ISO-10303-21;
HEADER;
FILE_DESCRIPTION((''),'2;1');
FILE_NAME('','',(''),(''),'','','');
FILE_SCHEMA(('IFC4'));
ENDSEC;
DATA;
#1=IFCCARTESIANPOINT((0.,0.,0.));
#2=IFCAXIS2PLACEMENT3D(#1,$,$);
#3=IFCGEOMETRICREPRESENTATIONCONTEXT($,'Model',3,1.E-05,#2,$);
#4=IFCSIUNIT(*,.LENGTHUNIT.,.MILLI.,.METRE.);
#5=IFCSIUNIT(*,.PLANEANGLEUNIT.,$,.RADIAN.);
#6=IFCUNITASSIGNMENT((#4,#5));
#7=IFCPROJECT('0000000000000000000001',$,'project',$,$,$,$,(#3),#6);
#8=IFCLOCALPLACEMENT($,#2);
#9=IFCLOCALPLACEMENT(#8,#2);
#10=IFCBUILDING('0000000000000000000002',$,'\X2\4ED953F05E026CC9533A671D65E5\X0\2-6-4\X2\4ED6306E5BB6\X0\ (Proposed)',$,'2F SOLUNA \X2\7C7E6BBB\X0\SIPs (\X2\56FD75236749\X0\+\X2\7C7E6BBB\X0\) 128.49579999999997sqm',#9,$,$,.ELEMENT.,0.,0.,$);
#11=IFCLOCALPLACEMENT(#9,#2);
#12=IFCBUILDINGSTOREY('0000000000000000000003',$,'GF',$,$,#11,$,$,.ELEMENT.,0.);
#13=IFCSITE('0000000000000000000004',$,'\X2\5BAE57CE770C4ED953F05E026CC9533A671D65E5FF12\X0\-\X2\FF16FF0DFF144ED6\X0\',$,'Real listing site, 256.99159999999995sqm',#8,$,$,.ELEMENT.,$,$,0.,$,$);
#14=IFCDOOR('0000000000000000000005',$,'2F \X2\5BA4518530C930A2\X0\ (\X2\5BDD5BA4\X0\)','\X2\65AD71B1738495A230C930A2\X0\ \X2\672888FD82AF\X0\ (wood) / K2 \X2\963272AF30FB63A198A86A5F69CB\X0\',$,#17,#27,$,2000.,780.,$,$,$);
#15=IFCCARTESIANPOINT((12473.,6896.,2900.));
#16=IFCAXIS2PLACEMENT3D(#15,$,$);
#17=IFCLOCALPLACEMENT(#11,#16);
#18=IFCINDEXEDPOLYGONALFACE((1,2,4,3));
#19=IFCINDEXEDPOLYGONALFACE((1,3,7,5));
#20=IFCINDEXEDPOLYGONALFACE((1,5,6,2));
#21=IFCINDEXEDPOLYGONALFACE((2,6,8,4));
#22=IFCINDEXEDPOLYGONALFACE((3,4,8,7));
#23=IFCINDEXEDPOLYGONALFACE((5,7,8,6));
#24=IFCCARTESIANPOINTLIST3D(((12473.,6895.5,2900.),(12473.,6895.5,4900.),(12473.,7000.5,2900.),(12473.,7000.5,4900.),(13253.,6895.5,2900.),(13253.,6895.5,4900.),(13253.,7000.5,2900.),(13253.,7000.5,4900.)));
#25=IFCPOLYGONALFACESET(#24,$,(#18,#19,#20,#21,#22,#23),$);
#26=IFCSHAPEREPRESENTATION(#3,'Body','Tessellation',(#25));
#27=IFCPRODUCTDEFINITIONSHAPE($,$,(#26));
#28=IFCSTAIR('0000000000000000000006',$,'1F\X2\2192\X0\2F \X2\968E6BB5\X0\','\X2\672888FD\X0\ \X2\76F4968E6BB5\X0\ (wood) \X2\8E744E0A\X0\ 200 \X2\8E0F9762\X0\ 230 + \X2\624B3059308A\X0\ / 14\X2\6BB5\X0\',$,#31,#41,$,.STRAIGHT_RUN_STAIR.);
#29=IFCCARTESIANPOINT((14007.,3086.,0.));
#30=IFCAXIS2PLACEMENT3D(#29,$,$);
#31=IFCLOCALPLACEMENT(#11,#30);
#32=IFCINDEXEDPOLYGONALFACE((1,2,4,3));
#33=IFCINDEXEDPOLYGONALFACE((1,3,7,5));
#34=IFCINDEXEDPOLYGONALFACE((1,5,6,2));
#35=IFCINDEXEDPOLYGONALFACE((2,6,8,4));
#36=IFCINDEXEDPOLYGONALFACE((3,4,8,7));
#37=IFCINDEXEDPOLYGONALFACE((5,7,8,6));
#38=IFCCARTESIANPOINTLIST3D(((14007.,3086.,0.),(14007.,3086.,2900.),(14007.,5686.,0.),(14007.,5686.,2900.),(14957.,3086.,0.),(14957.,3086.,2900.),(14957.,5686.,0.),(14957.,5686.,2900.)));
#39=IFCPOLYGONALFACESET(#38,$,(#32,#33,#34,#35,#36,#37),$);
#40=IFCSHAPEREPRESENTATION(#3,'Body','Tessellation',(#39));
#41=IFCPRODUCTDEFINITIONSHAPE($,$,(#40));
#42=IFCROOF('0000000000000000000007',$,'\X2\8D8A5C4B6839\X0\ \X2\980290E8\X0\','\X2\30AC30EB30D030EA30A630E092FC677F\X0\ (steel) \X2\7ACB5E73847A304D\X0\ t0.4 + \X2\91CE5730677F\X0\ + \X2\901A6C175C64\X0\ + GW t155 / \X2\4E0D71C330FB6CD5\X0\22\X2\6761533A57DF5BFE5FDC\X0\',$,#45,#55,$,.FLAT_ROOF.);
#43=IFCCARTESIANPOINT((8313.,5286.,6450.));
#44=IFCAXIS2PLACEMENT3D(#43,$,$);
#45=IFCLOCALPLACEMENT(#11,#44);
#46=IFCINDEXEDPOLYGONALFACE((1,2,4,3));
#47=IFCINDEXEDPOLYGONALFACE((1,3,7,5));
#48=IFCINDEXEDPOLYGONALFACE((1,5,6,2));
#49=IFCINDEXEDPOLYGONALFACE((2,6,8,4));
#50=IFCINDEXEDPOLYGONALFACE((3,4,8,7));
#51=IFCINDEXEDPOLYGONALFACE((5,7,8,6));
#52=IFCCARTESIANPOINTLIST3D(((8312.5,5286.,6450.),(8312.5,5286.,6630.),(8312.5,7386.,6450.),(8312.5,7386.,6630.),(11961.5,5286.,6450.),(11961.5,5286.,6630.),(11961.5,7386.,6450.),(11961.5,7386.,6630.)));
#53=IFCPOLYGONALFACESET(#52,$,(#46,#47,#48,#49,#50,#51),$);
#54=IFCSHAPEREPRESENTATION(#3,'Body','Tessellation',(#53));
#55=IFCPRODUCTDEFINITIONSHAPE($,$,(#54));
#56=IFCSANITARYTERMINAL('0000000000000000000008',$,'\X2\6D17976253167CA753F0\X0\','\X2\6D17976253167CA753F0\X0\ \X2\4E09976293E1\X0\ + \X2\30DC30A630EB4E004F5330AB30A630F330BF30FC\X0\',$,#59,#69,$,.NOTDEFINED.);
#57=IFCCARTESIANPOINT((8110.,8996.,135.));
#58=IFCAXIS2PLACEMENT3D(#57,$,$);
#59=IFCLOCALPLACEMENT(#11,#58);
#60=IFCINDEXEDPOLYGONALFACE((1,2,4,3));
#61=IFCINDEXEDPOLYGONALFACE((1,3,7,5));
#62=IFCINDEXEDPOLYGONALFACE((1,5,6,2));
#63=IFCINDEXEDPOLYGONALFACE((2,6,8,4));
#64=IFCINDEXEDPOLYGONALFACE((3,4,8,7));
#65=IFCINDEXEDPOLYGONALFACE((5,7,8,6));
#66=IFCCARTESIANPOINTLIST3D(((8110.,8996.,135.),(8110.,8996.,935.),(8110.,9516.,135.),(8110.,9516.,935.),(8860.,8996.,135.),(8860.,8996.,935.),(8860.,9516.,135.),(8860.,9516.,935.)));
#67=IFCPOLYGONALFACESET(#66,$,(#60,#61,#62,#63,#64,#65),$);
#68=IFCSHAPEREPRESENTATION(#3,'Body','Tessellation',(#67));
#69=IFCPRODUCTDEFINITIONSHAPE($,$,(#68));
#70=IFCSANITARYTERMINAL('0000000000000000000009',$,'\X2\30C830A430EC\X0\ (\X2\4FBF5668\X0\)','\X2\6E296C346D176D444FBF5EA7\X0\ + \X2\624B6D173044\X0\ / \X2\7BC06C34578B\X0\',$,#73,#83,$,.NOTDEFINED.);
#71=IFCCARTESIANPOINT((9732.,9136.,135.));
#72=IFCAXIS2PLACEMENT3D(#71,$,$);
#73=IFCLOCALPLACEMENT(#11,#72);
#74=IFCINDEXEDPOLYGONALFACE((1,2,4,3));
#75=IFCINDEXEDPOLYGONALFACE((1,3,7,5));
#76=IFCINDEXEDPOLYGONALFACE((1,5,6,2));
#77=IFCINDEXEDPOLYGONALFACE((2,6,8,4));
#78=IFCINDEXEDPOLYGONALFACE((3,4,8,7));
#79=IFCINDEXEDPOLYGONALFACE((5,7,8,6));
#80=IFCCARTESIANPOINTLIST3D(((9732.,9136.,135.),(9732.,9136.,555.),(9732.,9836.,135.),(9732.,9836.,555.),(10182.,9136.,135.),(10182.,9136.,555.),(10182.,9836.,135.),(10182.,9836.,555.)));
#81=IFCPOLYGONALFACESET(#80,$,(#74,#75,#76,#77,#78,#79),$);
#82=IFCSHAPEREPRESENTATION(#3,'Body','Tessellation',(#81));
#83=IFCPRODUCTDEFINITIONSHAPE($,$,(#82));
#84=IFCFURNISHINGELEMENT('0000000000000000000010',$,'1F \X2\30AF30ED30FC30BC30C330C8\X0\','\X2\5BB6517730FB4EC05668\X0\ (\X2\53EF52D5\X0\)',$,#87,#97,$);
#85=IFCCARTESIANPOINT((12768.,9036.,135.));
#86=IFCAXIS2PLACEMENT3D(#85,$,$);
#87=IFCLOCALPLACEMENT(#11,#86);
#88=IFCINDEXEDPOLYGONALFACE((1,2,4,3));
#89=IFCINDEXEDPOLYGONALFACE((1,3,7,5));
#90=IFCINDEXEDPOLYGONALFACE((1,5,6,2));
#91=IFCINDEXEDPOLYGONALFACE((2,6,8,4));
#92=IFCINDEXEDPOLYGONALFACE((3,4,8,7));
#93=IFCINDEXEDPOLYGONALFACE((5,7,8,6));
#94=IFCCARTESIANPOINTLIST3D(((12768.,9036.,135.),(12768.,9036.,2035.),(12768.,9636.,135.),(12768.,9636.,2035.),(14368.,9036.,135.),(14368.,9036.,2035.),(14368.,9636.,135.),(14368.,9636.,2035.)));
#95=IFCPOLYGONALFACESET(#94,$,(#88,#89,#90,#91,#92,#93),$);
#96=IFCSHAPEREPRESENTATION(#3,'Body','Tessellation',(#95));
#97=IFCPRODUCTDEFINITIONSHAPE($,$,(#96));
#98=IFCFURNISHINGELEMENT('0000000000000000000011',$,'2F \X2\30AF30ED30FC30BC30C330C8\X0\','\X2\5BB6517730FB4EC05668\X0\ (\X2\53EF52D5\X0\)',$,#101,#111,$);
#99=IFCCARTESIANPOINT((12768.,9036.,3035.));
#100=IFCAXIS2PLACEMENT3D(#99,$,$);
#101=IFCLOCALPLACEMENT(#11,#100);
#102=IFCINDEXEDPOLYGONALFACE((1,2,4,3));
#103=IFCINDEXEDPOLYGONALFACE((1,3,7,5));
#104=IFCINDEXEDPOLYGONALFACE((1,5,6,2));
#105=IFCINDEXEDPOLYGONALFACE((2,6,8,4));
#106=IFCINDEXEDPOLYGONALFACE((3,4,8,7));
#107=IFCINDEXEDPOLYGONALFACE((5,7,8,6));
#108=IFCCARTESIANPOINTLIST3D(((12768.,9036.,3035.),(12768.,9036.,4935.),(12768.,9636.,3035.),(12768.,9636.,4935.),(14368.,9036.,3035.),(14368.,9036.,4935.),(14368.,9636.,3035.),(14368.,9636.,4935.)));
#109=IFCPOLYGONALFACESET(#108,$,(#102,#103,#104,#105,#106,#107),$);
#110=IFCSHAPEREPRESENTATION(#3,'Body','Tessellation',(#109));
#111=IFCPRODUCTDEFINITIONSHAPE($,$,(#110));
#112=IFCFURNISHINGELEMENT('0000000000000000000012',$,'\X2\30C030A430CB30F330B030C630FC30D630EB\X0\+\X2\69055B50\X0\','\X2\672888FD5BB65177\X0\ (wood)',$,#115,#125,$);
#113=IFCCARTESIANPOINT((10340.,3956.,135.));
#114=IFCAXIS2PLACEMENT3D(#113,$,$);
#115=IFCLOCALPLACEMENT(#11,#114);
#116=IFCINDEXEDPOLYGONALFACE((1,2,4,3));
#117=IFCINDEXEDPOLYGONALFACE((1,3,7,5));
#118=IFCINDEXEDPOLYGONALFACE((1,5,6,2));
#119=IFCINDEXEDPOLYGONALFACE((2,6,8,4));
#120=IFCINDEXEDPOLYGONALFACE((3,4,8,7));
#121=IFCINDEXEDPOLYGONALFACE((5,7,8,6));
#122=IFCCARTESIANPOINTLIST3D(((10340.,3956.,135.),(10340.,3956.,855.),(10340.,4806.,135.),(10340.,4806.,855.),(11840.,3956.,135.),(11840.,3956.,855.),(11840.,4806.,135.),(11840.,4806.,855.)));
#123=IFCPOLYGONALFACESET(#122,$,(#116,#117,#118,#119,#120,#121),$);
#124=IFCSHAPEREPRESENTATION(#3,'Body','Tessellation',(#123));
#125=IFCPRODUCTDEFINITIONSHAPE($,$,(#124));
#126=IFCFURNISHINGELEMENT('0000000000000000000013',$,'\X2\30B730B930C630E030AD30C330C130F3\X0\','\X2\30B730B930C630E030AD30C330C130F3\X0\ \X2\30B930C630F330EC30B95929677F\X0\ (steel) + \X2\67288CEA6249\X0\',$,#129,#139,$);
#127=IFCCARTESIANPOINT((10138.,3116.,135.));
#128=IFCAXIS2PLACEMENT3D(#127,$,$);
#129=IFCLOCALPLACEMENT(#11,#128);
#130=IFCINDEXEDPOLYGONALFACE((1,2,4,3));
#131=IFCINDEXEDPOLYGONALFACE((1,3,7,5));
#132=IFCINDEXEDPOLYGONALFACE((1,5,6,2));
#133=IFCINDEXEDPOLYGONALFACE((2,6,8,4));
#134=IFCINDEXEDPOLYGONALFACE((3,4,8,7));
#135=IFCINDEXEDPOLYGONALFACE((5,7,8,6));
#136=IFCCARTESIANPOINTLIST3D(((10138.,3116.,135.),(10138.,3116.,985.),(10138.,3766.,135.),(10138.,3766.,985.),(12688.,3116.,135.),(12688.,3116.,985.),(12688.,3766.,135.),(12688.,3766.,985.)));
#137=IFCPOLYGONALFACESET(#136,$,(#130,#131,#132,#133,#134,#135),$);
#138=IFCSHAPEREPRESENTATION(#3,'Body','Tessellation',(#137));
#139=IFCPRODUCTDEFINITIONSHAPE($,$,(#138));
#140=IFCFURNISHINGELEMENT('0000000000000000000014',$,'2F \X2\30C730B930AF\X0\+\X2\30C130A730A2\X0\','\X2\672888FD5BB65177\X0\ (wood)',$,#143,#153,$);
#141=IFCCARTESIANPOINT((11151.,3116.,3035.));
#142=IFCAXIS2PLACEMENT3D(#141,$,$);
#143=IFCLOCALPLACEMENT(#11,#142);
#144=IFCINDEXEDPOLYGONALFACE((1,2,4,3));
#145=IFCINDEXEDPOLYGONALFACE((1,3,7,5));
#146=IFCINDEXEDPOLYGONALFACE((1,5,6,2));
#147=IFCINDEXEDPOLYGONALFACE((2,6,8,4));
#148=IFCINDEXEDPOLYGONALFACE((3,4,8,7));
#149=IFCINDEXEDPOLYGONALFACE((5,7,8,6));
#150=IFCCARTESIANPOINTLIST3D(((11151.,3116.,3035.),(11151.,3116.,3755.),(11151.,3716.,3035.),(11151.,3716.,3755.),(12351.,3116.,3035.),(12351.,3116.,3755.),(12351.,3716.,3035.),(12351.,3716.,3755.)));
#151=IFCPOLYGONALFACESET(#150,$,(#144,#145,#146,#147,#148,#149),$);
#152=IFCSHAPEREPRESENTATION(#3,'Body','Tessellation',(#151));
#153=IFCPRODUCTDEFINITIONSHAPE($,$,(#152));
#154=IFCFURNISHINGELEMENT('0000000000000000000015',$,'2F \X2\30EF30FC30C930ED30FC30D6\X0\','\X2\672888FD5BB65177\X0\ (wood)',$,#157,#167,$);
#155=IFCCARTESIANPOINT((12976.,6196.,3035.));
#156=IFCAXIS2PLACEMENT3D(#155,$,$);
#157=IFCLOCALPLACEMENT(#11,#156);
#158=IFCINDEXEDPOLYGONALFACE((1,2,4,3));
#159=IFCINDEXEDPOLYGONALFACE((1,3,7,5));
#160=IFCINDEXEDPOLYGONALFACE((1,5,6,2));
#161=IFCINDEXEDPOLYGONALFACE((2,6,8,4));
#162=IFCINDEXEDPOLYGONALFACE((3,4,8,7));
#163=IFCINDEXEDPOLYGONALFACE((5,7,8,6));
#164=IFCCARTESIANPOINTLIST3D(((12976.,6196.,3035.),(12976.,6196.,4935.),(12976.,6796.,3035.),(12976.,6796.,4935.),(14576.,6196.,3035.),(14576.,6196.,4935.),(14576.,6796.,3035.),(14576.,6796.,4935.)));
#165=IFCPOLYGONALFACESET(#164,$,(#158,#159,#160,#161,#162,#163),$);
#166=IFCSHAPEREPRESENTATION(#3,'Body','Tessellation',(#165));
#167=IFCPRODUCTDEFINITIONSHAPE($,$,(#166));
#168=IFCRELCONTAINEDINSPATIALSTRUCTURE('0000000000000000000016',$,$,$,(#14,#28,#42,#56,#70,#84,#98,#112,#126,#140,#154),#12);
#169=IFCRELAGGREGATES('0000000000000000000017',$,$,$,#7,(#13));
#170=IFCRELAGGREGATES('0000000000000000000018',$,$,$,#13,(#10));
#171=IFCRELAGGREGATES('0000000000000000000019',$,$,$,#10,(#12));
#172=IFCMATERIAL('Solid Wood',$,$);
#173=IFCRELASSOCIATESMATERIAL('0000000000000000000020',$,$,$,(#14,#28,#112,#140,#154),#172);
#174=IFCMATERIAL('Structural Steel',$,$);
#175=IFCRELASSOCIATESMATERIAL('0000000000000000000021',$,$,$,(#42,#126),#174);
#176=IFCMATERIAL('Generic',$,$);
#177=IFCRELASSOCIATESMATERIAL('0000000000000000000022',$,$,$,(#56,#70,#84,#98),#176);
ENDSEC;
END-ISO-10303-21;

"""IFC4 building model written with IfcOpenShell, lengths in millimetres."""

from ifc_helpers import new_model, si_unit, frame, frame_2d, origin, place, context, project, spatial, rectangle, extrude, material, element, save


model = new_model("IFC4")

# Units and contexts
model_context = context("Model", 3, precision=1e-05, world=origin())
ifc_project = project(units=[si_unit("LENGTHUNIT", "METRE", prefix="MILLI"), si_unit("PLANEANGLEUNIT", "RADIAN")], contexts=[model_context])

# Site, building, storey
site_placement = place(None, origin())
site = spatial("IfcSite", under=ifc_project, at=site_placement, Name="宮城県仙台市泉区朝日２-６－４他", ObjectType="Real listing site, 256.99159999999995sqm", CompositionType="ELEMENT", RefElevation=0.0)
building_placement = place(site_placement, origin())
building = spatial("IfcBuilding", under=site, at=building_placement, Name="仙台市泉区朝日2-6-4他の家 (Proposed)", ObjectType="2F SOLUNA 籾殻SIPs (国産杉+籾殻) 128.49579999999997sqm", CompositionType="ELEMENT", ElevationOfRefHeight=0.0, ElevationOfTerrain=0.0)
storey_placement = place(building_placement, origin())
storey = spatial("IfcBuildingStorey", under=building, at=storey_placement, Name="GF", CompositionType="ELEMENT", Elevation=0.0)

# Shared definitions
ifc_material_1 = material(Name="Solid Wood")

# Door
door_1_placement = place(storey_placement, frame((12473.0, 6896.0, 2900.0)))
element("IfcDoor", 1, at=door_1_placement, inside=storey, material=ifc_material_1, Name="2F 室内ドア (寝室)", Description="断熱玄関ドア 木製芯 (wood) / K2 防犯・採風機構", OverallHeight=2000.0, OverallWidth=780.0, context=model_context, shape_type="SweptSolid", body=[
    extrude(rectangle(XDim=780.0, YDim=105.0, at=frame_2d((390.0, 52.0))), frame((12473.0, 6896.0, 2900.0)), (0.0, 0.0, 1.0), 2000.0),
])

# Stair
stair_placement = place(storey_placement, frame((14007.0, 3086.0, 0.0)))
element("IfcStair", 2, at=stair_placement, inside=storey, material=ifc_material_1, Name="1F→2F 階段", Description="木製 直階段 (wood) 蹴上 200 踏面 230 + 手すり / 14段", PredefinedType="STRAIGHT_RUN_STAIR", context=model_context, shape_type="SweptSolid", body=[
    extrude(rectangle(XDim=950.0, YDim=2600.0, at=frame_2d((475.0, 1300.0))), frame((14007.0, 3086.0, 0.0)), (0.0, 0.0, 1.0), 2900.0),
])

# Roof
ifc_material_2 = material(Name="Structural Steel")
roof_placement = place(storey_placement, frame((8313.0, 5286.0, 6450.0)))
element("IfcRoof", 3, at=roof_placement, inside=storey, material=ifc_material_2, Name="越屋根 頂部", Description="ガルバリウム鋼板 (steel) 立平葺き t0.4 + 野地板 + 通気層 + GW t155 / 不燃・法22条区域対応", PredefinedType="FLAT_ROOF", context=model_context, shape_type="SweptSolid", body=[
    extrude(rectangle(XDim=3649.0, YDim=2100.0, at=frame_2d((1824.0, 1050.0))), frame((8313.0, 5286.0, 6450.0)), (0.0, 0.0, 1.0), 180.0),
])

# Sanitary terminals
ifc_material_3 = material(Name="Generic")
sanitary_terminal_1_placement = place(storey_placement, frame((8110.0, 8996.0, 135.0)))
element("IfcSanitaryTerminal", 4, at=sanitary_terminal_1_placement, inside=storey, material=ifc_material_3, Name="洗面化粧台", Description="洗面化粧台 三面鏡 + ボウル一体カウンター", PredefinedType="NOTDEFINED", context=model_context, shape_type="SweptSolid", body=[
    extrude(rectangle(XDim=750.0, YDim=520.0, at=frame_2d((375.0, 260.0))), frame((8110.0, 8996.0, 135.0)), (0.0, 0.0, 1.0), 800.0),
])
sanitary_terminal_2_placement = place(storey_placement, frame((9732.0, 9136.0, 135.0)))
element("IfcSanitaryTerminal", 5, at=sanitary_terminal_2_placement, inside=storey, material=ifc_material_3, Name="トイレ (便器)", Description="温水洗浄便座 + 手洗い / 節水型", PredefinedType="NOTDEFINED", context=model_context, shape_type="SweptSolid", body=[
    extrude(rectangle(XDim=450.0, YDim=700.0, at=frame_2d((225.0, 350.0))), frame((9732.0, 9136.0, 135.0)), (0.0, 0.0, 1.0), 420.0),
])

# Furnishing elements
furnishing_1_placement = place(storey_placement, frame((12768.0, 9036.0, 135.0)))
element("IfcFurnishingElement", 6, at=furnishing_1_placement, inside=storey, material=ifc_material_3, Name="1F クローゼット", Description="家具・什器 (可動)", context=model_context, shape_type="SweptSolid", body=[
    extrude(rectangle(XDim=1600.0, YDim=600.0, at=frame_2d((800.0, 300.0))), frame((12768.0, 9036.0, 135.0)), (0.0, 0.0, 1.0), 1900.0),
])
furnishing_2_placement = place(storey_placement, frame((12768.0, 9036.0, 3035.0)))
element("IfcFurnishingElement", 7, at=furnishing_2_placement, inside=storey, material=ifc_material_3, Name="2F クローゼット", Description="家具・什器 (可動)", context=model_context, shape_type="SweptSolid", body=[
    extrude(rectangle(XDim=1600.0, YDim=600.0, at=frame_2d((800.0, 300.0))), frame((12768.0, 9036.0, 3035.0)), (0.0, 0.0, 1.0), 1900.0),
])
furnishing_3_placement = place(storey_placement, frame((10340.0, 3956.0, 135.0)))
element("IfcFurnishingElement", 8, at=furnishing_3_placement, inside=storey, material=ifc_material_1, Name="ダイニングテーブル+椅子", Description="木製家具 (wood)", context=model_context, shape_type="SweptSolid", body=[
    extrude(rectangle(XDim=1500.0, YDim=850.0, at=frame_2d((750.0, 425.0))), frame((10340.0, 3956.0, 135.0)), (0.0, 0.0, 1.0), 720.0),
])
furnishing_4_placement = place(storey_placement, frame((10138.0, 3116.0, 135.0)))
element("IfcFurnishingElement", 9, at=furnishing_4_placement, inside=storey, material=ifc_material_2, Name="システムキッチン", Description="システムキッチン ステンレス天板 (steel) + 木質扉", context=model_context, shape_type="SweptSolid", body=[
    extrude(rectangle(XDim=2550.0, YDim=650.0, at=frame_2d((1275.0, 325.0))), frame((10138.0, 3116.0, 135.0)), (0.0, 0.0, 1.0), 850.0),
])
furnishing_5_placement = place(storey_placement, frame((11151.0, 3116.0, 3035.0)))
element("IfcFurnishingElement", 10, at=furnishing_5_placement, inside=storey, material=ifc_material_1, Name="2F デスク+チェア", Description="木製家具 (wood)", context=model_context, shape_type="SweptSolid", body=[
    extrude(rectangle(XDim=1200.0, YDim=600.0, at=frame_2d((600.0, 300.0))), frame((11151.0, 3116.0, 3035.0)), (0.0, 0.0, 1.0), 720.0),
])
furnishing_6_placement = place(storey_placement, frame((12976.0, 6196.0, 3035.0)))
element("IfcFurnishingElement", 11, at=furnishing_6_placement, inside=storey, material=ifc_material_1, Name="2F ワードローブ", Description="木製家具 (wood)", context=model_context, shape_type="SweptSolid", body=[
    extrude(rectangle(XDim=1600.0, YDim=600.0, at=frame_2d((800.0, 300.0))), frame((12976.0, 6196.0, 3035.0)), (0.0, 0.0, 1.0), 1900.0),
])

save(model, "model.ifc")
